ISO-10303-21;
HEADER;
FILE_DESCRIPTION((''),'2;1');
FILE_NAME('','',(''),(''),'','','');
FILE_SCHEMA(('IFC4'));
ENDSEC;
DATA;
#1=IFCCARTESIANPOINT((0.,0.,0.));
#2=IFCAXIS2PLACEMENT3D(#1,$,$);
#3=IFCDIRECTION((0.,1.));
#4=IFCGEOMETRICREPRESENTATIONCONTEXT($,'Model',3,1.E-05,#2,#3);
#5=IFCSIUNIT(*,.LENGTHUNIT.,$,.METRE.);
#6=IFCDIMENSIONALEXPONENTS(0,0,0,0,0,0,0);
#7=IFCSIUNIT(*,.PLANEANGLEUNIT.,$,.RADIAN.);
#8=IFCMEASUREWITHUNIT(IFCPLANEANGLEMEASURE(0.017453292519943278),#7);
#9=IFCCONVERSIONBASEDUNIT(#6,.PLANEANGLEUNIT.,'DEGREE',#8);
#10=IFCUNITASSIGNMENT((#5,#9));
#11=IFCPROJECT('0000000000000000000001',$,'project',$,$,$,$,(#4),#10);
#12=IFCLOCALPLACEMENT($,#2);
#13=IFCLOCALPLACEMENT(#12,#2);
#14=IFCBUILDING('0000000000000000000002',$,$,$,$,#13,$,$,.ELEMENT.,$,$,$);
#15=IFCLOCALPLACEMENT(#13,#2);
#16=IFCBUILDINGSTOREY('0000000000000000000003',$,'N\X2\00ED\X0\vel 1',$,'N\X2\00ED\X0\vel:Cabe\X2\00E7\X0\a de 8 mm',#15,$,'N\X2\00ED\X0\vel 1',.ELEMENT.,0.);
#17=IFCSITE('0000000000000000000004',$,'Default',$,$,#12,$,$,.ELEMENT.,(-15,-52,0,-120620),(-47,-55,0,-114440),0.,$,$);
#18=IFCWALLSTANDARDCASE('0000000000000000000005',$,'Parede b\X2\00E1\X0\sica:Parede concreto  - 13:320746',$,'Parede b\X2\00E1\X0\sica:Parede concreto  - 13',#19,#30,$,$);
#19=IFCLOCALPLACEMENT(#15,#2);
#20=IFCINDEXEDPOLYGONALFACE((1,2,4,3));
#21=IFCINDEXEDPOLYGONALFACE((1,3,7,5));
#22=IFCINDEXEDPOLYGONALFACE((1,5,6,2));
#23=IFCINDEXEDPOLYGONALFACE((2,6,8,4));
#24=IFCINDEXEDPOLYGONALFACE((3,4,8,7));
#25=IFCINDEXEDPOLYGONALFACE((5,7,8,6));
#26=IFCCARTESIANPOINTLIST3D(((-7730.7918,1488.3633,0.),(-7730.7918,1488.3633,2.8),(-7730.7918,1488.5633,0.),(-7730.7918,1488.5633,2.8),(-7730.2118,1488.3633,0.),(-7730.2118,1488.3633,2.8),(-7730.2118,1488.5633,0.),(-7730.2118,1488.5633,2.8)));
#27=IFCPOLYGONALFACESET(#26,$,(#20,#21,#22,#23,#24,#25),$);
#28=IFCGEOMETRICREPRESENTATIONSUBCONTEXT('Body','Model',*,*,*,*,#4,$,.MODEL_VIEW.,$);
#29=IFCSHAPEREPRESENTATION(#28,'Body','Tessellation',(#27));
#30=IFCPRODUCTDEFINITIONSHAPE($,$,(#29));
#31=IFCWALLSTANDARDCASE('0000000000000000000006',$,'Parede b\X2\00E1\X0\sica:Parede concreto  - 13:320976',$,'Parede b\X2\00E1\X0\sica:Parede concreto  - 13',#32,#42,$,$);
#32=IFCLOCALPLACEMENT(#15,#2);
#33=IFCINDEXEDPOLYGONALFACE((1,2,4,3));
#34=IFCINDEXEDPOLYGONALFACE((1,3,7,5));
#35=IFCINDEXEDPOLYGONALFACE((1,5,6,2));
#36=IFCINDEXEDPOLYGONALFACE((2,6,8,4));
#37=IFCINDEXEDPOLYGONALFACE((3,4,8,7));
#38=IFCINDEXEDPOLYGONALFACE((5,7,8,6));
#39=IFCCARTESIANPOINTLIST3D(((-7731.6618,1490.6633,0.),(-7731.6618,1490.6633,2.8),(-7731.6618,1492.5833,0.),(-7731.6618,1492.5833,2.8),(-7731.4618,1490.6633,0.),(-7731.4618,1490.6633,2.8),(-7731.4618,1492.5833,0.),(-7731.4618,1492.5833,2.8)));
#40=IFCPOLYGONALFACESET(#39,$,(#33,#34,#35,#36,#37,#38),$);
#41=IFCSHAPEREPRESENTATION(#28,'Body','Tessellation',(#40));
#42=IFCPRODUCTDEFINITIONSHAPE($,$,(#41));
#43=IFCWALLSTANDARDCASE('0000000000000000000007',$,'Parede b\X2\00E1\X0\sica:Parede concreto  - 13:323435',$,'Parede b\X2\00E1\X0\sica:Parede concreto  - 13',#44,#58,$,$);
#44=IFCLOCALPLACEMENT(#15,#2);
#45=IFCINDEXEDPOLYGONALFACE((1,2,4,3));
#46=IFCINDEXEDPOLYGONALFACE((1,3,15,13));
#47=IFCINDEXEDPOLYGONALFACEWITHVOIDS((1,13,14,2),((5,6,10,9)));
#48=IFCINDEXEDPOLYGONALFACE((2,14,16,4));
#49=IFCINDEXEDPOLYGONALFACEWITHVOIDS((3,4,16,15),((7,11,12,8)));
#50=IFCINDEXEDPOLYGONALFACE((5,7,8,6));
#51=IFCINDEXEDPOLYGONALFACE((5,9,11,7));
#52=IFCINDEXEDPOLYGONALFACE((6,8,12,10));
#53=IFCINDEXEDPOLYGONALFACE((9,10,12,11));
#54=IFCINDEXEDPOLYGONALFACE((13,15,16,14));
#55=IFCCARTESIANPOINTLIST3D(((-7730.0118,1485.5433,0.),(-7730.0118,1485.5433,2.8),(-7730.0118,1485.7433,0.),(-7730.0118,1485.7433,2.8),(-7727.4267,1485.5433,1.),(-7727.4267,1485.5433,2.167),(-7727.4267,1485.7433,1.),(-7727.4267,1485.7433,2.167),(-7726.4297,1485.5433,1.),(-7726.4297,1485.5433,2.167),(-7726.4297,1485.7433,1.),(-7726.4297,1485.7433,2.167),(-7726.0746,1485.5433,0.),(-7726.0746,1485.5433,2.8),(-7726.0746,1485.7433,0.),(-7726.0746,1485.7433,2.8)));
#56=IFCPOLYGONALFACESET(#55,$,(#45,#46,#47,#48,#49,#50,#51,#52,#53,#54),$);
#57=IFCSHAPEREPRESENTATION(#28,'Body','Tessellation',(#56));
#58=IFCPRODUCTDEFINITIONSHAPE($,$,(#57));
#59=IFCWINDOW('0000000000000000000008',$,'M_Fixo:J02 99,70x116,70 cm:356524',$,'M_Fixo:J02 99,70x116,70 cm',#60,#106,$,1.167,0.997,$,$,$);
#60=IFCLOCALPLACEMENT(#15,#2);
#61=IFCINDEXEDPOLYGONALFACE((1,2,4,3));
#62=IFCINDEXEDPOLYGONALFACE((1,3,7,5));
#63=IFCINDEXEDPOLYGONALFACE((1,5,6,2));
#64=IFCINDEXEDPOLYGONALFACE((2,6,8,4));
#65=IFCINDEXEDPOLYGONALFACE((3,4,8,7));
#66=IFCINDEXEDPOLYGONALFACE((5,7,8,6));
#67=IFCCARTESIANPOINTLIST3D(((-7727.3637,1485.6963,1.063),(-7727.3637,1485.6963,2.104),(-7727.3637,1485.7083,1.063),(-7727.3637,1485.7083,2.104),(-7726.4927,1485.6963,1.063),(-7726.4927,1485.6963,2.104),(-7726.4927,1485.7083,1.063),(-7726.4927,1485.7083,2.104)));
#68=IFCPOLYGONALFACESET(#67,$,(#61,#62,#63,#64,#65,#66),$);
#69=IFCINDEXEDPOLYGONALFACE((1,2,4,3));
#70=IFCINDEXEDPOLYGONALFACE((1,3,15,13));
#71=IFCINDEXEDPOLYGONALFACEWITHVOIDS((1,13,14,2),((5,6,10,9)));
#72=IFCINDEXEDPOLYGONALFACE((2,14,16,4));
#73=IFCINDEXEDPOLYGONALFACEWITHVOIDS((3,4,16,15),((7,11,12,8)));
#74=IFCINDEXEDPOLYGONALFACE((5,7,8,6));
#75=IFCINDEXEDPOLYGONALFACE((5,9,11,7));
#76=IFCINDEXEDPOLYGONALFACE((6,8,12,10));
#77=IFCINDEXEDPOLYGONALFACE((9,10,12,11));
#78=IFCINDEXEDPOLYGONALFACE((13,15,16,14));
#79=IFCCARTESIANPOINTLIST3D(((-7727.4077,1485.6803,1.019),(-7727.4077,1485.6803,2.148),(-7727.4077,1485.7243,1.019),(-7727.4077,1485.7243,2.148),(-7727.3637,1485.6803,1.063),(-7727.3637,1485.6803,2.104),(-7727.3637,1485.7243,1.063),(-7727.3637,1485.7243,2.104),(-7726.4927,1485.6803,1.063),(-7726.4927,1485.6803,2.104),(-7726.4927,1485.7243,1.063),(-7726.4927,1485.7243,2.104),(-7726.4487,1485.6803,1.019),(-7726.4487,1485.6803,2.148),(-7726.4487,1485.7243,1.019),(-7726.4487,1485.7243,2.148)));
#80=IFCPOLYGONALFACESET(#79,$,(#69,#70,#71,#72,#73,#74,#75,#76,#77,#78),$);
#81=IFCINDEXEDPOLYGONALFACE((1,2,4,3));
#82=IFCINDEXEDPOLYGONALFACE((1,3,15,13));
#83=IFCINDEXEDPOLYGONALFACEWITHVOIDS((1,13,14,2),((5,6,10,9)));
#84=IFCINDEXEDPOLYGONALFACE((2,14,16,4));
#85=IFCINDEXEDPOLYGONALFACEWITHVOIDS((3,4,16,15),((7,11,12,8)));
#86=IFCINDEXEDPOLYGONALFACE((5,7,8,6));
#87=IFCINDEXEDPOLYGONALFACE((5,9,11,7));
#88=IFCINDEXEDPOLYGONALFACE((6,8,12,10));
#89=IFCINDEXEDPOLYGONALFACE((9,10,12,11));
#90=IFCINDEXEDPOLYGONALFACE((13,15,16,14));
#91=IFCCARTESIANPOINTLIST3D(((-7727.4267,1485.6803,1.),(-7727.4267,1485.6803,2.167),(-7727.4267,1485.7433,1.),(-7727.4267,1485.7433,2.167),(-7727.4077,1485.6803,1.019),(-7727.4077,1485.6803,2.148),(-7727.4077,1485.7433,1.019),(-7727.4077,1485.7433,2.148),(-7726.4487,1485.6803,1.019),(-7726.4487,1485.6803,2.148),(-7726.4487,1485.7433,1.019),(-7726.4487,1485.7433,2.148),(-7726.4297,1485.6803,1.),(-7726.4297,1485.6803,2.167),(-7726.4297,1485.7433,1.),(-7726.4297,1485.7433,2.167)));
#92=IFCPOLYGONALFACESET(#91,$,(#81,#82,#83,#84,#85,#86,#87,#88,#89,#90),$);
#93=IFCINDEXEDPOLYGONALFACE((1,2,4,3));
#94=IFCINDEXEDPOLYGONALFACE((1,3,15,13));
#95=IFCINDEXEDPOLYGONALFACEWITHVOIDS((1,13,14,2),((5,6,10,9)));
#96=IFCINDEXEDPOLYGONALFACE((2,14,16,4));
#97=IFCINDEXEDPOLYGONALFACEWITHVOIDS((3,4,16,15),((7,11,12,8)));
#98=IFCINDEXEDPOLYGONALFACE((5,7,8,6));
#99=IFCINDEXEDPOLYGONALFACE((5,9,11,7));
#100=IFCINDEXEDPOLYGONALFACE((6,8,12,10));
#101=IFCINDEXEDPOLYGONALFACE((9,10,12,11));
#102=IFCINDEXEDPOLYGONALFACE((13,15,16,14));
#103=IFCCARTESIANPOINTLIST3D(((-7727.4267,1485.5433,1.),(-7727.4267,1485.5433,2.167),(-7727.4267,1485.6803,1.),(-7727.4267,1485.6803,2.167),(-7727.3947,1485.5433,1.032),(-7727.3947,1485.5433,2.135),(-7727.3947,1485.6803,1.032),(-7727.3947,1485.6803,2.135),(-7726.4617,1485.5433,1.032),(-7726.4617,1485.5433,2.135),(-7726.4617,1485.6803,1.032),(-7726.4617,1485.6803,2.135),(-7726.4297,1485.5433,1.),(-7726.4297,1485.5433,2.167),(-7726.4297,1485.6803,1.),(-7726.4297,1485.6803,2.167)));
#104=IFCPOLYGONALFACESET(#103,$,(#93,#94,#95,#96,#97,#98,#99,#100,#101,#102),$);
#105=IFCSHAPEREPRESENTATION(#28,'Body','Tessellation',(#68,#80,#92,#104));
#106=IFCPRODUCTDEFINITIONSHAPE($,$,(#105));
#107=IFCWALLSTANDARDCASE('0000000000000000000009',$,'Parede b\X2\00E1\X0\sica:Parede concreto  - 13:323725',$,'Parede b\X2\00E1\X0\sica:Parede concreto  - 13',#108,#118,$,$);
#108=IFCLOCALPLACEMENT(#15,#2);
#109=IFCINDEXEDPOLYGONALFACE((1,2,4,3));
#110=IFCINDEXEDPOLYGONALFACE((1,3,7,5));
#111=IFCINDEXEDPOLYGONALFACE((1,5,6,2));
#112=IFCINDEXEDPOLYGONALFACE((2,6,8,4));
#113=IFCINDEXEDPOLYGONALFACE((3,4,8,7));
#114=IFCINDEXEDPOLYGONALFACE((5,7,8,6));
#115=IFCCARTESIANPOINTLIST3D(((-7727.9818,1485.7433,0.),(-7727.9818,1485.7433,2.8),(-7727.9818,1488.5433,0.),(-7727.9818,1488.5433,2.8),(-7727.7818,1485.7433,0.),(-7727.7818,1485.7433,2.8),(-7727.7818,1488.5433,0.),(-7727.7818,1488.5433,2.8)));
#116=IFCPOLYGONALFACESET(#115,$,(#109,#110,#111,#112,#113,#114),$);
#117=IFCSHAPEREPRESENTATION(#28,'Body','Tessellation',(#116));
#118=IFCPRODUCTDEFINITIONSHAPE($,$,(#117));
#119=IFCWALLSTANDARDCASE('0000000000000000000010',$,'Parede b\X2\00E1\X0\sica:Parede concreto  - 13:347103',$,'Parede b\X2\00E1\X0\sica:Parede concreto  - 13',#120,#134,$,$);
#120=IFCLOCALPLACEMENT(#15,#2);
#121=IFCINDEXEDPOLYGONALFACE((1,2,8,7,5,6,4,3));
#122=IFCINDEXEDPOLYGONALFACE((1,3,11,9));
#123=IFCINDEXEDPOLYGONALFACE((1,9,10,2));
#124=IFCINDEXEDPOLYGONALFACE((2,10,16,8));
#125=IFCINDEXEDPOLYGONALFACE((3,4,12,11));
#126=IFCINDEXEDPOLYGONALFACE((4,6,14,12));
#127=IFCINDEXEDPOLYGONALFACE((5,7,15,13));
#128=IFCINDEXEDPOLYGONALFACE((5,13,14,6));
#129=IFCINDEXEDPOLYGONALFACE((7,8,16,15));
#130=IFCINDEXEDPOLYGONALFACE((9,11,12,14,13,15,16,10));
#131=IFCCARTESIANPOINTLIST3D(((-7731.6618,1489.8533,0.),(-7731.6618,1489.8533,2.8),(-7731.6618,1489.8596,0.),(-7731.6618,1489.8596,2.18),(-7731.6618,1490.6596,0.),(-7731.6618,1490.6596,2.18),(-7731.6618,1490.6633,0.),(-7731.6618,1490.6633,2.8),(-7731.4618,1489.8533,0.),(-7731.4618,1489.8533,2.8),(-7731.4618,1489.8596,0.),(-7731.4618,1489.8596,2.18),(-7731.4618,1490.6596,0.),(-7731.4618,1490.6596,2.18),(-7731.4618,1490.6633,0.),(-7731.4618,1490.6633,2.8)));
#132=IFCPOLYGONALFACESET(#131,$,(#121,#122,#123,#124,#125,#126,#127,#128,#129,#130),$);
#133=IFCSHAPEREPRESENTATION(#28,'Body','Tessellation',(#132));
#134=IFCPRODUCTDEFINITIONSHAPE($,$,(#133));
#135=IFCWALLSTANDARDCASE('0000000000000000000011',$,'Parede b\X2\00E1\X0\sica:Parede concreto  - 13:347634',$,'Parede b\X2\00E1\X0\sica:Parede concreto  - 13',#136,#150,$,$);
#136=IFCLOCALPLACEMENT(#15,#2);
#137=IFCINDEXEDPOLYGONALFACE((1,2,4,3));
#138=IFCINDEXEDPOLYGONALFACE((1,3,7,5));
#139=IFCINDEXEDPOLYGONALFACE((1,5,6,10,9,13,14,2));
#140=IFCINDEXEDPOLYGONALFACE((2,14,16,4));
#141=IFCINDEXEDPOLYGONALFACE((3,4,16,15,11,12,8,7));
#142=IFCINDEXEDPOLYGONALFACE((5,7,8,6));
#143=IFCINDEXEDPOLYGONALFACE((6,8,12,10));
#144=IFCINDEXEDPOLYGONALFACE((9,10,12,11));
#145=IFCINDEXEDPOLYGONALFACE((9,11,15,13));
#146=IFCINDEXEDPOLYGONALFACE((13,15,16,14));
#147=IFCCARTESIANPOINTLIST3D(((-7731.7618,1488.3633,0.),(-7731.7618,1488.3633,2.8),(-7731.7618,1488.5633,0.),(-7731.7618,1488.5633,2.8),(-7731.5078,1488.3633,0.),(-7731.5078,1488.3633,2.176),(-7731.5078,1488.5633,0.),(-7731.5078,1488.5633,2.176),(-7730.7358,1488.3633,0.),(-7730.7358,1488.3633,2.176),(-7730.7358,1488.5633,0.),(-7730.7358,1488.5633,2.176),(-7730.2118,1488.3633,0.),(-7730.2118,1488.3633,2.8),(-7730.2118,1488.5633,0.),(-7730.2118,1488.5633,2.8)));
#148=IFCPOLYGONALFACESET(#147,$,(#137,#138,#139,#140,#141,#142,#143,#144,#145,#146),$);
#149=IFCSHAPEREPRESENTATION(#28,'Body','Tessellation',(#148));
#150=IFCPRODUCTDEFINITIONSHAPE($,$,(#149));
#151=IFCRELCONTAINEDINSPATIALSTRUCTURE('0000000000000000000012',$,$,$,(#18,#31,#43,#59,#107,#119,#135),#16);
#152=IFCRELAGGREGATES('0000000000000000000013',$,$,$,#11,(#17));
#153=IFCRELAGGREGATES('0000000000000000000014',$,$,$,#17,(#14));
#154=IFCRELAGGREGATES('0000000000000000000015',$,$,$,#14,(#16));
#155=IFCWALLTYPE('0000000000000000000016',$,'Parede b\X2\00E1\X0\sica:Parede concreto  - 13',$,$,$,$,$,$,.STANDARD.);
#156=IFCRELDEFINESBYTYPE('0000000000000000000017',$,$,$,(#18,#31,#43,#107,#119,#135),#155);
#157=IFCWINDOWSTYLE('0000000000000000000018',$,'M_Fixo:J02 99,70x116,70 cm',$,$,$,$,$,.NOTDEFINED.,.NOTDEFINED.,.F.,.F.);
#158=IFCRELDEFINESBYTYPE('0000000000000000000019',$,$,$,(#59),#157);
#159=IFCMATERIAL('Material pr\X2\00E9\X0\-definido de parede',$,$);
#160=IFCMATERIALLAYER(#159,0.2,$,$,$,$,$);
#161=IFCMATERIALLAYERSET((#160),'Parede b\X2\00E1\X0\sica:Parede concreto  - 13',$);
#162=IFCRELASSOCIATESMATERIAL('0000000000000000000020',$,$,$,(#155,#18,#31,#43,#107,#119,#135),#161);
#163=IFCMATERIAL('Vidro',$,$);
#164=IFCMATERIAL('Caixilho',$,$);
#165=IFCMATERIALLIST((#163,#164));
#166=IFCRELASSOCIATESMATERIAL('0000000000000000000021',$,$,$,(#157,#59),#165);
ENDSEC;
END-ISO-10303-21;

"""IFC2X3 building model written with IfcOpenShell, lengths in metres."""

from ifc_helpers import new_model, entity, si_unit, converted_unit, direction, frame, frame_2d, origin, place, context, subcontext, project, spatial, polyline, rectangle, outline, extrude, source, transform, mapped, material, material_list, layer, layer_set, layer_usage, type_object, type_shapes, element, fill, save


model = new_model("IFC2X3")

# Units and contexts
model_context = context("Model", 3, precision=1e-05, world=origin(), true_north=direction((0.0, 1.0)))
body_context = subcontext(model_context, "Body", "Model", "MODEL_VIEW")
ifc_project = project(units=[si_unit("LENGTHUNIT", "METRE"), converted_unit("PLANEANGLEUNIT", "DEGREE", entity("IfcPlaneAngleMeasure", 0.017453292519943278), si_unit("PLANEANGLEUNIT", "RADIAN"), dimensions=[0, 0, 0, 0, 0, 0, 0])], contexts=[model_context])

# Site, building, storey
site_placement = place(None, origin())
site = spatial("IfcSite", under=ifc_project, at=site_placement, Name="Default", CompositionType="ELEMENT", RefLatitude=(-15, -52, 0, -120620), RefLongitude=(-47, -55, 0, -114440), RefElevation=0.0)
building_placement = place(site_placement, origin())
building = spatial("IfcBuilding", under=site, at=building_placement, CompositionType="ELEMENT")
storey_placement = place(building_placement, origin())
storey = spatial("IfcBuildingStorey", under=building, at=storey_placement, Name="Nível 1", ObjectType="Nível:Cabeça de 8 mm", LongName="Nível 1", CompositionType="ELEMENT", Elevation=0.0)

# Shared definitions
ifc_material_1 = material(Name="Material pré-definido de parede")
ifc_layer_1 = layer(ifc_material_1, 0.2)
ifc_layer_set_1 = layer_set([ifc_layer_1], Name="Parede básica:Parede concreto  - 13")
wall_type_1 = type_object("IfcWallType", Name="Parede básica:Parede concreto  - 13", PredefinedType="STANDARD", material=ifc_layer_set_1)
ifc_material_2 = material(Name="Vidro")
ifc_material_3 = material(Name="Caixilho")
ifc_material_list = material_list([ifc_material_2, ifc_material_3])

# Walls
ifc_layer_usage_1 = layer_usage(ifc_layer_set_1, "AXIS2", "NEGATIVE", 0.1)
wall_1_placement = place(storey_placement, frame((-7730.7918, 1488.4633, 0.0)))
element("IfcWallStandardCase", 1, at=wall_1_placement, inside=storey, type_object=wall_type_1, material=ifc_layer_usage_1, Name="Parede básica:Parede concreto  - 13:320746", ObjectType="Parede básica:Parede concreto  - 13", context=body_context, shape_type="SweptSolid", body=[
    extrude(rectangle(XDim=0.58, YDim=0.2, at=frame_2d((0.29, 0.0), x_axis=(-1.0, 0.0))), origin(), (0.0, 0.0, 1.0), 2.8),
])
ifc_layer_usage_2 = layer_usage(ifc_layer_set_1, "AXIS2", "NEGATIVE", 0.1)
wall_2_placement = place(storey_placement, frame((-7731.5618, 1490.6633, 0.0), z_axis=(0.0, 0.0, 1.0), x_axis=(0.0, 1.0, 0.0)))
element("IfcWallStandardCase", 2, at=wall_2_placement, inside=storey, type_object=wall_type_1, material=ifc_layer_usage_2, Name="Parede básica:Parede concreto  - 13:320976", ObjectType="Parede básica:Parede concreto  - 13", context=body_context, shape_type="SweptSolid", body=[
    extrude(rectangle(XDim=1.92, YDim=0.2, at=frame_2d((0.96, 0.0), x_axis=(-1.0, 0.0))), origin(), (0.0, 0.0, 1.0), 2.8),
])

# Wall, opening, window
ifc_layer_usage_3 = layer_usage(ifc_layer_set_1, "AXIS2", "NEGATIVE", 0.1)
wall_3_placement = place(storey_placement, frame((-7730.0118, 1485.6433, 0.0)))
wall_3 = element("IfcWallStandardCase", 3, at=wall_3_placement, inside=storey, type_object=wall_type_1, material=ifc_layer_usage_3, Name="Parede básica:Parede concreto  - 13:323435", ObjectType="Parede básica:Parede concreto  - 13", context=body_context, shape_type="SweptSolid", body=[
    extrude(rectangle(XDim=3.9372, YDim=0.2, at=frame_2d((1.9686, 0.0), x_axis=(-1.0, 0.0))), origin(), (0.0, 0.0, 1.0), 2.8),
])
opening_1_placement = place(wall_3_placement, frame((2.5851, -0.1, 1.0)))
opening_1 = element("IfcOpeningElement", 4, at=opening_1_placement, cuts=wall_3, ObjectType="Opening", context=body_context, shape_type="SweptSolid", body=[
    extrude(rectangle(XDim=1.167, YDim=0.997, at=frame_2d((0.5835, 0.4985), x_axis=(1.0, 0.0))), frame((0.0, 0.0, 0.0), z_axis=(0.0, 1.0, 0.0), x_axis=(0.0, 0.0, 1.0)), (0.0, 0.0, 1.0), 0.2),
])
window_style_1 = type_object("IfcWindowStyle", Name="M_Fixo:J02 99,70x116,70 cm", ConstructionType="NOTDEFINED", OperationType="NOTDEFINED", ParameterTakesPrecedence=False, Sizeable=False, material=ifc_material_list)
shared_shape_1 = source(origin(), body_context, "Body", "SweptSolid", [
    extrude(rectangle(XDim=0.012, YDim=0.871, at=frame_2d((0.0, 0.0), x_axis=(1.0, 0.0))), frame((0.4985, 0.159, 0.063), z_axis=(0.0, 0.0, 1.0), x_axis=(0.0, -1.0, 0.0)), (0.0, 0.0, 1.0), 1.041),
    extrude(outline(polyline([(-0.4795, -0.5645), (0.4795, -0.5645), (0.4795, 0.5645), (-0.4795, 0.5645), (-0.4795, -0.5645)]), holes=[polyline([(-0.4355, -0.5205), (-0.4355, 0.5205), (0.4355, 0.5205), (0.4355, -0.5205), (-0.4355, -0.5205)])]), frame((0.4985, 0.137, 0.5835), z_axis=(0.0, 1.0, 0.0), x_axis=(1.0, 0.0, 0.0)), (0.0, 0.0, 1.0), 0.044),
    extrude(outline(polyline([(-0.4985, -0.5835), (0.4985, -0.5835), (0.4985, 0.5835), (-0.4985, 0.5835), (-0.4985, -0.5835)]), holes=[polyline([(-0.4795, -0.5645), (-0.4795, 0.5645), (0.4795, 0.5645), (0.4795, -0.5645), (-0.4795, -0.5645)])]), frame((0.4985, 0.137, 0.5835), z_axis=(0.0, 1.0, 0.0), x_axis=(1.0, 0.0, 0.0)), (0.0, 0.0, 1.0), 0.063),
    extrude(outline(polyline([(-0.4985, -0.5835), (0.4985, -0.5835), (0.4985, 0.5835), (-0.4985, 0.5835), (-0.4985, -0.5835)]), holes=[polyline([(-0.4665, -0.5515), (-0.4665, 0.5515), (0.4665, 0.5515), (0.4665, -0.5515), (-0.4665, -0.5515)])]), frame((0.4985, 0.0, 0.5835), z_axis=(0.0, 1.0, 0.0), x_axis=(1.0, 0.0, 0.0)), (0.0, 0.0, 1.0), 0.137),
])
type_shapes(window_style_1, [shared_shape_1])
window_1_placement = place(opening_1_placement, origin())
window_1 = element("IfcWindow", 5, at=window_1_placement, inside=storey, type_object=window_style_1, material=ifc_material_list, Name="M_Fixo:J02 99,70x116,70 cm:356524", ObjectType="M_Fixo:J02 99,70x116,70 cm", OverallHeight=1.167, OverallWidth=0.997, context=body_context, shape_type="MappedRepresentation", body=[
    mapped(shared_shape_1, transform((0.0, 0.0, 0.0), scale=1.0)),
])
fill(opening_1, window_1)

# Wall
ifc_layer_usage_4 = layer_usage(ifc_layer_set_1, "AXIS2", "NEGATIVE", 0.1)
wall_4_placement = place(storey_placement, frame((-7727.8818, 1485.7433, 0.0), z_axis=(0.0, 0.0, 1.0), x_axis=(0.0, 1.0, 0.0)))
element("IfcWallStandardCase", 6, at=wall_4_placement, inside=storey, type_object=wall_type_1, material=ifc_layer_usage_4, Name="Parede básica:Parede concreto  - 13:323725", ObjectType="Parede básica:Parede concreto  - 13", context=body_context, shape_type="SweptSolid", body=[
    extrude(rectangle(XDim=2.8, YDim=0.2, at=frame_2d((1.4, 0.0), x_axis=(-1.0, 0.0))), origin(), (0.0, 0.0, 1.0), 2.8),
])

# Walls, openings
ifc_layer_usage_5 = layer_usage(ifc_layer_set_1, "AXIS2", "POSITIVE", -0.1)
wall_5_placement = place(storey_placement, frame((-7731.5618, 1490.6633, 0.0), z_axis=(0.0, 0.0, 1.0), x_axis=(0.0, -1.0, 0.0)))
wall_5 = element("IfcWallStandardCase", 7, at=wall_5_placement, inside=storey, type_object=wall_type_1, material=ifc_layer_usage_5, Name="Parede básica:Parede concreto  - 13:347103", ObjectType="Parede básica:Parede concreto  - 13", context=body_context, shape_type="SweptSolid", body=[
    extrude(rectangle(XDim=0.81, YDim=0.2, at=frame_2d((0.405, 0.0), x_axis=(-1.0, 0.0))), origin(), (0.0, 0.0, 1.0), 2.8),
])
opening_2_placement = place(wall_5_placement, origin())
element("IfcOpeningElement", 8, at=opening_2_placement, cuts=wall_5, ObjectType="Opening", context=body_context, shape_type="SweptSolid", body=[
    extrude(rectangle(XDim=2.18, YDim=0.8, at=frame_2d((0.0, 0.0), x_axis=(0.0, 1.0))), frame((0.4037, 0.1, 1.09), z_axis=(0.0, -1.0, 0.0), x_axis=(1.0, 0.0, 0.0)), (0.0, 0.0, 1.0), 0.2),
])
ifc_layer_usage_6 = layer_usage(ifc_layer_set_1, "AXIS2", "NEGATIVE", 0.1)
wall_6_placement = place(storey_placement, frame((-7730.2118, 1488.4633, 0.0), z_axis=(0.0, 0.0, 1.0), x_axis=(-1.0, 0.0, 0.0)))
wall_6 = element("IfcWallStandardCase", 9, at=wall_6_placement, inside=storey, type_object=wall_type_1, material=ifc_layer_usage_6, Name="Parede básica:Parede concreto  - 13:347634", ObjectType="Parede básica:Parede concreto  - 13", context=body_context, shape_type="SweptSolid", body=[
    extrude(rectangle(XDim=1.55, YDim=0.2, at=frame_2d((0.775, 0.0), x_axis=(-1.0, 0.0))), origin(), (0.0, 0.0, 1.0), 2.8),
])
opening_3_placement = place(wall_6_placement, origin())
element("IfcOpeningElement", 10, at=opening_3_placement, cuts=wall_6, ObjectType="Opening", context=body_context, shape_type="SweptSolid", body=[
    extrude(rectangle(XDim=2.176, YDim=0.772, at=frame_2d((0.0, 0.0), x_axis=(0.0, 1.0))), frame((0.91, 0.1, 1.088), z_axis=(0.0, -1.0, 0.0), x_axis=(1.0, 0.0, 0.0)), (0.0, 0.0, 1.0), 0.2),
])

save(model, "model.ifc")
